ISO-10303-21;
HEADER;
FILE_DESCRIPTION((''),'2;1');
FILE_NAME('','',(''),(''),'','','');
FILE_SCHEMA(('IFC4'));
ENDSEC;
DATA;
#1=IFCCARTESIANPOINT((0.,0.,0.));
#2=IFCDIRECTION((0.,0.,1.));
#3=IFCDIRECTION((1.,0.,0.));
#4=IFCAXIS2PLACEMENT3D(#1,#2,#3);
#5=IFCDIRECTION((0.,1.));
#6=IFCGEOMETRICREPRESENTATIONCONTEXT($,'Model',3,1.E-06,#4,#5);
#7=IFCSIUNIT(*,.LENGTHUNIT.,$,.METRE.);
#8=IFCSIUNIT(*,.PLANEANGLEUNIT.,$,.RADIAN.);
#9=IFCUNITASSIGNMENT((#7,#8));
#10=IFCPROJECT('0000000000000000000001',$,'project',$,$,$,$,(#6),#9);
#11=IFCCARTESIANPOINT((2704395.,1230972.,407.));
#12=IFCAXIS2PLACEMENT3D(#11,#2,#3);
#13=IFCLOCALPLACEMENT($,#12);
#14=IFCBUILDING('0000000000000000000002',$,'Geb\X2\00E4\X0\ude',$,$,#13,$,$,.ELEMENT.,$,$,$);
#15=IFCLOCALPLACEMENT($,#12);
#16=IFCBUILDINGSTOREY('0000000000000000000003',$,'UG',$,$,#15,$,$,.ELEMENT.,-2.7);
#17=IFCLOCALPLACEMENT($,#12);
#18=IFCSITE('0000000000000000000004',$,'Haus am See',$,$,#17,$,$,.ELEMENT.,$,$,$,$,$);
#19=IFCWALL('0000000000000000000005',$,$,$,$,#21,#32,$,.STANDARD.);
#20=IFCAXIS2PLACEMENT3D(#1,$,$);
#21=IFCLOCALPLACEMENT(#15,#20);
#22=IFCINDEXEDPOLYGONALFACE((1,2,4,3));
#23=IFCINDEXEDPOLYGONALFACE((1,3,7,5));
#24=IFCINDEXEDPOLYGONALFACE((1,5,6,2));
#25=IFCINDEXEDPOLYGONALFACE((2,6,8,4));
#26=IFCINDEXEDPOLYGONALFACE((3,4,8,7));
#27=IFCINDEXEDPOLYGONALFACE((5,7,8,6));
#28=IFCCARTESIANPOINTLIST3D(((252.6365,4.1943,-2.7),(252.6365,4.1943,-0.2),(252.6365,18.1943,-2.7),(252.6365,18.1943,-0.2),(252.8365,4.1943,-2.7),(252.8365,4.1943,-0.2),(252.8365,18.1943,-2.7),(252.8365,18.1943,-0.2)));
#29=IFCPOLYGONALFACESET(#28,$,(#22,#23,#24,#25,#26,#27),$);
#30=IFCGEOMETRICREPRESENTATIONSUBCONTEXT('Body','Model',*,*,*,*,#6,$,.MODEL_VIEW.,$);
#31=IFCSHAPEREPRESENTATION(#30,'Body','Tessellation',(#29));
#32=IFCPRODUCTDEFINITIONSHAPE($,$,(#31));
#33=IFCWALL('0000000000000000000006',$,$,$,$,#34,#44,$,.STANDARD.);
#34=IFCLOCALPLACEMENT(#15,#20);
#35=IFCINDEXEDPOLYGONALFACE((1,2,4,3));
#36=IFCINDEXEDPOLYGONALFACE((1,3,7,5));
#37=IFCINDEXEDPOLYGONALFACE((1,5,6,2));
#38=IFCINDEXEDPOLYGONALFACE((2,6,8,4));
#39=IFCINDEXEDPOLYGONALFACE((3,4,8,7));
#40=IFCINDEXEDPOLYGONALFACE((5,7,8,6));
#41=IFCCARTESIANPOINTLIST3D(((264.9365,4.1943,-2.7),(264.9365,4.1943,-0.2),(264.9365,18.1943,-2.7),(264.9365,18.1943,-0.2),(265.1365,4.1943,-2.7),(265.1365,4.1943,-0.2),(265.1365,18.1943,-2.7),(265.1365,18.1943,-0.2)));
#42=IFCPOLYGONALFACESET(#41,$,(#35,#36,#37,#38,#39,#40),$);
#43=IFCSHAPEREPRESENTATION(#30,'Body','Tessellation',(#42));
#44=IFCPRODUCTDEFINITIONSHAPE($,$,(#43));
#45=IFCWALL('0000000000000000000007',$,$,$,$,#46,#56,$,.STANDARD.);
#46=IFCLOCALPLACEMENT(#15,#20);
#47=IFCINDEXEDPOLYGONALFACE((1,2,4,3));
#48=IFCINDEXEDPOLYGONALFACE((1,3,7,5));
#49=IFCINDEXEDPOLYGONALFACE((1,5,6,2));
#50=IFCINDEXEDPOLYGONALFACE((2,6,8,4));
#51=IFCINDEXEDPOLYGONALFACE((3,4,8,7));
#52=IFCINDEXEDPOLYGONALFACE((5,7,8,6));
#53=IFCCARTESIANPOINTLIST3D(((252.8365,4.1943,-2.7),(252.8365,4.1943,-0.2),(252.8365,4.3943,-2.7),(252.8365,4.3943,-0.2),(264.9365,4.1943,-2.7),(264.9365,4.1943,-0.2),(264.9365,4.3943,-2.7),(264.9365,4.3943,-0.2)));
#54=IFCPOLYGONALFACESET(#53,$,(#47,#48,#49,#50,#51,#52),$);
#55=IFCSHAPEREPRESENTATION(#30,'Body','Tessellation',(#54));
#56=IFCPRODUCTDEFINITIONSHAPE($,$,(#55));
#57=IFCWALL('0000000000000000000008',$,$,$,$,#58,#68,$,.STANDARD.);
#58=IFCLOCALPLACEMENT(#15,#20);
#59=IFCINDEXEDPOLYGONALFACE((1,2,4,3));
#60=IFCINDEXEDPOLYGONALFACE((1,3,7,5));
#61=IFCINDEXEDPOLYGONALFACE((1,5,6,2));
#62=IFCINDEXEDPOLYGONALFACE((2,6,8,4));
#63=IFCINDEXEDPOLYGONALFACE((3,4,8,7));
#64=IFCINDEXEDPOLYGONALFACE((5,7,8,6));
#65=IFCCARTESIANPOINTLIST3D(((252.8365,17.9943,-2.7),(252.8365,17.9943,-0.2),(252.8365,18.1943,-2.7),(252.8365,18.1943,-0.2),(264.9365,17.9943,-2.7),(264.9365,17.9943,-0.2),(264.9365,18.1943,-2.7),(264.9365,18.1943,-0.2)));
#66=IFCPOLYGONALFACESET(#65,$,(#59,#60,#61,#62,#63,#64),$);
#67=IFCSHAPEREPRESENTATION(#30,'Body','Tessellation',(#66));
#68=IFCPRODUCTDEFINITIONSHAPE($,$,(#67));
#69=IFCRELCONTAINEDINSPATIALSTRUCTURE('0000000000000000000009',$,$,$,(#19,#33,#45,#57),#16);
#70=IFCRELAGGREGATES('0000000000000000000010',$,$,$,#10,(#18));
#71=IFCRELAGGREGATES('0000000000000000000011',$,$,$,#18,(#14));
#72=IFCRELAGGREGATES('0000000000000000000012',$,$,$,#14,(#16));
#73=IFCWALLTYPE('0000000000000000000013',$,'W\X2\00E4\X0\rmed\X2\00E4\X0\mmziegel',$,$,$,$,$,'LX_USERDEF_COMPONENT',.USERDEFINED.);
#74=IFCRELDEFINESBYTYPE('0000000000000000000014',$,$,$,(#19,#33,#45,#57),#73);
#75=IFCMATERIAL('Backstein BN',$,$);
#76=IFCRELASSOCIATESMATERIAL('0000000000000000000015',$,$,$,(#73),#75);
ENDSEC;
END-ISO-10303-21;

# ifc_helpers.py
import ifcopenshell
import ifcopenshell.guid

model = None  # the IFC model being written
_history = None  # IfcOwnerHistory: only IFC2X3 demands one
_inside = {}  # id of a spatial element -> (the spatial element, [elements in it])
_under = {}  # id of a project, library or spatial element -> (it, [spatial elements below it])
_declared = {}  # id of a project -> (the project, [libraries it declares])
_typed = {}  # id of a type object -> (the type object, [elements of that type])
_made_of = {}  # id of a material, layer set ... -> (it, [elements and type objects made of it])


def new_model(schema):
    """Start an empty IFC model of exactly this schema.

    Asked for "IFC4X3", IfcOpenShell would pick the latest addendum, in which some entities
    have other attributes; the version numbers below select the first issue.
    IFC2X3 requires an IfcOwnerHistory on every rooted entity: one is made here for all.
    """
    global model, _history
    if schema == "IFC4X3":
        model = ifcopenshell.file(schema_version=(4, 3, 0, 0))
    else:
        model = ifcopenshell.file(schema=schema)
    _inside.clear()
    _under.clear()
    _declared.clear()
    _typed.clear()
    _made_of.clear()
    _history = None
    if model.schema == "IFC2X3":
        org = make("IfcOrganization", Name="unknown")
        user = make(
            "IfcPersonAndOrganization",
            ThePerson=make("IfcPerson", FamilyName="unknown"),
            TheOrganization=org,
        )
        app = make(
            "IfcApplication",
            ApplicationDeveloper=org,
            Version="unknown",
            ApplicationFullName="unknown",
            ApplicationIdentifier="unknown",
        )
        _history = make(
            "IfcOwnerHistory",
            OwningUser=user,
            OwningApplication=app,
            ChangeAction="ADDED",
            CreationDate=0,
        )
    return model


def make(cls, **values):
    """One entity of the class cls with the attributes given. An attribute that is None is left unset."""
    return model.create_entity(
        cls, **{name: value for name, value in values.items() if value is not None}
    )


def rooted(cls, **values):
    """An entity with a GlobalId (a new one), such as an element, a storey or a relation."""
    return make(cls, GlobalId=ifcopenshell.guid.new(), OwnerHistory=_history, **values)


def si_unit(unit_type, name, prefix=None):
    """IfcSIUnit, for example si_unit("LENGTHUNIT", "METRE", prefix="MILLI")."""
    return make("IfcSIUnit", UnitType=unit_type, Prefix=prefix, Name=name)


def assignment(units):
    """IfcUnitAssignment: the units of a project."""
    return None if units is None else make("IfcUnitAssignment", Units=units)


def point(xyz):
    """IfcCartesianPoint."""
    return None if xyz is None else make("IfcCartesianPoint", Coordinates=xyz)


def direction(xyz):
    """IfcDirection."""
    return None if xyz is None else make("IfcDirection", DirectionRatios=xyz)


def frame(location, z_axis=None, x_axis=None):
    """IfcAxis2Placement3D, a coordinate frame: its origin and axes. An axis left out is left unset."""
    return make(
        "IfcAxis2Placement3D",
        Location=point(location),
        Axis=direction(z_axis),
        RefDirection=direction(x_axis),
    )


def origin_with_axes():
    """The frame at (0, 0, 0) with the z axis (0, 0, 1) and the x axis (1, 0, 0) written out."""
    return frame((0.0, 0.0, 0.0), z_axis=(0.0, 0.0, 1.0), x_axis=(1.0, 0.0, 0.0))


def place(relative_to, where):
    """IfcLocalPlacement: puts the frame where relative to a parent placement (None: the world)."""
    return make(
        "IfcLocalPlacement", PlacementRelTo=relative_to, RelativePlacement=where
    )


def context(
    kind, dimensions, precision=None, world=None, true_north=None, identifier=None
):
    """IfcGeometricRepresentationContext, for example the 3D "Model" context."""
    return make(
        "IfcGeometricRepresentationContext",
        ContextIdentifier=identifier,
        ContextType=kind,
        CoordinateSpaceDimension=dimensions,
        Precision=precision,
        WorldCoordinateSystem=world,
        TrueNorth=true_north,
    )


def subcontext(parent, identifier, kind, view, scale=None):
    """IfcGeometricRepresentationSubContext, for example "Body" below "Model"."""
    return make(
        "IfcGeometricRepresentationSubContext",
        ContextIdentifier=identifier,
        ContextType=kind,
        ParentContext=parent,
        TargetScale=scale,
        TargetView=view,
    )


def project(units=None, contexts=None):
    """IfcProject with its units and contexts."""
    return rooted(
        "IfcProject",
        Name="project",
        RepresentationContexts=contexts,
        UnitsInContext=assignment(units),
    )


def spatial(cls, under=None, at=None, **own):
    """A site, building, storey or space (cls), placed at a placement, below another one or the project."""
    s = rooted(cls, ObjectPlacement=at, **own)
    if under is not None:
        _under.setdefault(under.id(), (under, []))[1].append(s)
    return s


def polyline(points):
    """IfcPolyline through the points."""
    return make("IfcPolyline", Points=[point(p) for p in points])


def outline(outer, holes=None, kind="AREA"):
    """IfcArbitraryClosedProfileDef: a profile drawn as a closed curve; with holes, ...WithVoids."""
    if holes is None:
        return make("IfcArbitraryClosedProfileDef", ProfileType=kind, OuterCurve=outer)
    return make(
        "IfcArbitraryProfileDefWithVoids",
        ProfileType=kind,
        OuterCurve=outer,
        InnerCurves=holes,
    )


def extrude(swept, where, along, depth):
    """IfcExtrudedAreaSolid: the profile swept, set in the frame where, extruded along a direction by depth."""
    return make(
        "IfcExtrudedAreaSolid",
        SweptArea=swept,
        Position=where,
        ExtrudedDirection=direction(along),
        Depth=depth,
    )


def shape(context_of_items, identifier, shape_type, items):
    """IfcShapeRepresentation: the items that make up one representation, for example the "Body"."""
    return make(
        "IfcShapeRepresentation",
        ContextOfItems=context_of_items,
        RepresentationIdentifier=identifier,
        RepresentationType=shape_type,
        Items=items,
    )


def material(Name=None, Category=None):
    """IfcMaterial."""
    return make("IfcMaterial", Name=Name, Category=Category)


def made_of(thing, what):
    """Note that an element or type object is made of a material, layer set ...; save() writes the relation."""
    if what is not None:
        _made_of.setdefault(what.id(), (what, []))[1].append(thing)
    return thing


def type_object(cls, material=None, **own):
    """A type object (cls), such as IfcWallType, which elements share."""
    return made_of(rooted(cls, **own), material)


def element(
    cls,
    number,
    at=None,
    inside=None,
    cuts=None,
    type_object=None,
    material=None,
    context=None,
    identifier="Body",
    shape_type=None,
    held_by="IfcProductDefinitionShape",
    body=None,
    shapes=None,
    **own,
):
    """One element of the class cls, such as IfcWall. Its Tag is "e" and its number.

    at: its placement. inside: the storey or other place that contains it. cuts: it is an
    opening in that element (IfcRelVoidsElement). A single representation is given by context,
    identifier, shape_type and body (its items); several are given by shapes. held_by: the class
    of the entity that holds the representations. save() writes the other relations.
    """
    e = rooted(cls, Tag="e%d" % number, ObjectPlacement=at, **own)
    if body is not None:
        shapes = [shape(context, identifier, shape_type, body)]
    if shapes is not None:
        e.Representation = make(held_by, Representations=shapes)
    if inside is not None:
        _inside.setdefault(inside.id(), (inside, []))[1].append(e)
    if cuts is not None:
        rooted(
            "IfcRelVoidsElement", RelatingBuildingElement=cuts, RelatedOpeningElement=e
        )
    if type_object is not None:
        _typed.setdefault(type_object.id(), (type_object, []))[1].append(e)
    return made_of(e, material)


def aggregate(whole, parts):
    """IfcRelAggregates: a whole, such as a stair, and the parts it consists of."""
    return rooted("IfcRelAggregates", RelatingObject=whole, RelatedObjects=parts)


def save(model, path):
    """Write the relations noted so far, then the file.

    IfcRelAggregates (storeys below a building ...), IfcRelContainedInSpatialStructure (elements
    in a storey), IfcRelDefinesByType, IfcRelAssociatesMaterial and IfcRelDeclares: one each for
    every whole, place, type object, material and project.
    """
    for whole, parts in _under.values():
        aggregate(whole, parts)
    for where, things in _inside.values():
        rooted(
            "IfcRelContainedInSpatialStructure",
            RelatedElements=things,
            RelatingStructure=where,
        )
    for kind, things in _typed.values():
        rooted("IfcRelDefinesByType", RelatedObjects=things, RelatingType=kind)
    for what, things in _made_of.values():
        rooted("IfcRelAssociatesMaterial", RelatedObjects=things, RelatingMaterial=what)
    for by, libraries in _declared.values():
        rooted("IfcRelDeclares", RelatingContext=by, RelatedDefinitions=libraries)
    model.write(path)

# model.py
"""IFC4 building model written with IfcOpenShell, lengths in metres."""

from ifc_helpers import new_model, si_unit, direction, frame, origin_with_axes, place, context, subcontext, project, spatial, polyline, outline, extrude, material, type_object, element, save


model = new_model("IFC4")

# Units and contexts
model_context = context("Model", 3, precision=1e-06, world=origin_with_axes(), true_north=direction((0.0, 1.0)))
body_context = subcontext(model_context, "Body", "Model", "MODEL_VIEW")
ifc_project = project(units=[si_unit("LENGTHUNIT", "METRE"), si_unit("PLANEANGLEUNIT", "RADIAN")], contexts=[model_context])

# Site, building, storey
site_placement = place(None, frame((2704395.0, 1230972.0, 407.0), z_axis=(0.0, 0.0, 1.0), x_axis=(1.0, 0.0, 0.0)))
site = spatial("IfcSite", under=ifc_project, at=site_placement, Name="Haus am See", CompositionType="ELEMENT")
building_placement = place(None, frame((2704395.0, 1230972.0, 407.0), z_axis=(0.0, 0.0, 1.0), x_axis=(1.0, 0.0, 0.0)))
building = spatial("IfcBuilding", under=site, at=building_placement, Name="Gebäude", CompositionType="ELEMENT")
storey_placement = place(None, frame((2704395.0, 1230972.0, 407.0), z_axis=(0.0, 0.0, 1.0), x_axis=(1.0, 0.0, 0.0)))
storey = spatial("IfcBuildingStorey", under=building, at=storey_placement, Name="UG", CompositionType="ELEMENT", Elevation=-2.7)

# Walls
ifc_material_1 = material(Name="Backstein BN")
wall_type = type_object("IfcWallType", Name="Wärmedämmziegel", ElementType="LX_USERDEF_COMPONENT", PredefinedType="USERDEFINED", material=ifc_material_1)
wall_1_placement = place(storey_placement, frame((252.6365, 18.1943, -2.7), z_axis=(0.0, 0.0, 1.0), x_axis=(0.0, -1.0, 0.0)))
element("IfcWall", 1, at=wall_1_placement, inside=storey, type_object=wall_type, PredefinedType="STANDARD", context=body_context, shape_type="SweptSolid", body=[
    extrude(outline(polyline([(0.0, 0.0, 0.0), (14.0, 0.0, 0.0), (14.0, 0.2, 0.0), (0.0, 0.2, 0.0), (0.0, 0.0, 0.0)])), origin_with_axes(), (0.0, 0.0, 1.0), 2.5),
])
wall_2_placement = place(storey_placement, frame((265.1365, 4.1943, -2.7), z_axis=(0.0, 0.0, 1.0), x_axis=(0.0, 1.0, 0.0)))
element("IfcWall", 2, at=wall_2_placement, inside=storey, type_object=wall_type, PredefinedType="STANDARD", context=body_context, shape_type="SweptSolid", body=[
    extrude(outline(polyline([(0.0, 0.0, 0.0), (14.0, 0.0, 0.0), (14.0, 0.2, 0.0), (0.0, 0.2, 0.0), (0.0, 0.0, 0.0)])), origin_with_axes(), (0.0, 0.0, 1.0), 2.5),
])
wall_3_placement = place(storey_placement, frame((252.8365, 4.1943, -2.7), z_axis=(0.0, 0.0, 1.0), x_axis=(1.0, 0.0, 0.0)))
element("IfcWall", 3, at=wall_3_placement, inside=storey, type_object=wall_type, PredefinedType="STANDARD", context=body_context, shape_type="SweptSolid", body=[
    extrude(outline(polyline([(0.0, 0.0, 0.0), (12.1, 0.0, 0.0), (12.1, 0.2, 0.0), (0.0, 0.2, 0.0), (0.0, 0.0, 0.0)])), origin_with_axes(), (0.0, 0.0, 1.0), 2.5),
])
wall_4_placement = place(storey_placement, frame((264.9365, 18.1943, -2.7), z_axis=(0.0, 0.0, 1.0), x_axis=(-1.0, 0.0, 0.0)))
element("IfcWall", 4, at=wall_4_placement, inside=storey, type_object=wall_type, PredefinedType="STANDARD", context=body_context, shape_type="SweptSolid", body=[
    extrude(outline(polyline([(0.0, 0.0, 0.0), (12.1, 0.0, 0.0), (12.1, 0.2, 0.0), (0.0, 0.2, 0.0), (0.0, 0.0, 0.0)])), origin_with_axes(), (0.0, 0.0, 1.0), 2.5),
])

save(model, "model.ifc")
